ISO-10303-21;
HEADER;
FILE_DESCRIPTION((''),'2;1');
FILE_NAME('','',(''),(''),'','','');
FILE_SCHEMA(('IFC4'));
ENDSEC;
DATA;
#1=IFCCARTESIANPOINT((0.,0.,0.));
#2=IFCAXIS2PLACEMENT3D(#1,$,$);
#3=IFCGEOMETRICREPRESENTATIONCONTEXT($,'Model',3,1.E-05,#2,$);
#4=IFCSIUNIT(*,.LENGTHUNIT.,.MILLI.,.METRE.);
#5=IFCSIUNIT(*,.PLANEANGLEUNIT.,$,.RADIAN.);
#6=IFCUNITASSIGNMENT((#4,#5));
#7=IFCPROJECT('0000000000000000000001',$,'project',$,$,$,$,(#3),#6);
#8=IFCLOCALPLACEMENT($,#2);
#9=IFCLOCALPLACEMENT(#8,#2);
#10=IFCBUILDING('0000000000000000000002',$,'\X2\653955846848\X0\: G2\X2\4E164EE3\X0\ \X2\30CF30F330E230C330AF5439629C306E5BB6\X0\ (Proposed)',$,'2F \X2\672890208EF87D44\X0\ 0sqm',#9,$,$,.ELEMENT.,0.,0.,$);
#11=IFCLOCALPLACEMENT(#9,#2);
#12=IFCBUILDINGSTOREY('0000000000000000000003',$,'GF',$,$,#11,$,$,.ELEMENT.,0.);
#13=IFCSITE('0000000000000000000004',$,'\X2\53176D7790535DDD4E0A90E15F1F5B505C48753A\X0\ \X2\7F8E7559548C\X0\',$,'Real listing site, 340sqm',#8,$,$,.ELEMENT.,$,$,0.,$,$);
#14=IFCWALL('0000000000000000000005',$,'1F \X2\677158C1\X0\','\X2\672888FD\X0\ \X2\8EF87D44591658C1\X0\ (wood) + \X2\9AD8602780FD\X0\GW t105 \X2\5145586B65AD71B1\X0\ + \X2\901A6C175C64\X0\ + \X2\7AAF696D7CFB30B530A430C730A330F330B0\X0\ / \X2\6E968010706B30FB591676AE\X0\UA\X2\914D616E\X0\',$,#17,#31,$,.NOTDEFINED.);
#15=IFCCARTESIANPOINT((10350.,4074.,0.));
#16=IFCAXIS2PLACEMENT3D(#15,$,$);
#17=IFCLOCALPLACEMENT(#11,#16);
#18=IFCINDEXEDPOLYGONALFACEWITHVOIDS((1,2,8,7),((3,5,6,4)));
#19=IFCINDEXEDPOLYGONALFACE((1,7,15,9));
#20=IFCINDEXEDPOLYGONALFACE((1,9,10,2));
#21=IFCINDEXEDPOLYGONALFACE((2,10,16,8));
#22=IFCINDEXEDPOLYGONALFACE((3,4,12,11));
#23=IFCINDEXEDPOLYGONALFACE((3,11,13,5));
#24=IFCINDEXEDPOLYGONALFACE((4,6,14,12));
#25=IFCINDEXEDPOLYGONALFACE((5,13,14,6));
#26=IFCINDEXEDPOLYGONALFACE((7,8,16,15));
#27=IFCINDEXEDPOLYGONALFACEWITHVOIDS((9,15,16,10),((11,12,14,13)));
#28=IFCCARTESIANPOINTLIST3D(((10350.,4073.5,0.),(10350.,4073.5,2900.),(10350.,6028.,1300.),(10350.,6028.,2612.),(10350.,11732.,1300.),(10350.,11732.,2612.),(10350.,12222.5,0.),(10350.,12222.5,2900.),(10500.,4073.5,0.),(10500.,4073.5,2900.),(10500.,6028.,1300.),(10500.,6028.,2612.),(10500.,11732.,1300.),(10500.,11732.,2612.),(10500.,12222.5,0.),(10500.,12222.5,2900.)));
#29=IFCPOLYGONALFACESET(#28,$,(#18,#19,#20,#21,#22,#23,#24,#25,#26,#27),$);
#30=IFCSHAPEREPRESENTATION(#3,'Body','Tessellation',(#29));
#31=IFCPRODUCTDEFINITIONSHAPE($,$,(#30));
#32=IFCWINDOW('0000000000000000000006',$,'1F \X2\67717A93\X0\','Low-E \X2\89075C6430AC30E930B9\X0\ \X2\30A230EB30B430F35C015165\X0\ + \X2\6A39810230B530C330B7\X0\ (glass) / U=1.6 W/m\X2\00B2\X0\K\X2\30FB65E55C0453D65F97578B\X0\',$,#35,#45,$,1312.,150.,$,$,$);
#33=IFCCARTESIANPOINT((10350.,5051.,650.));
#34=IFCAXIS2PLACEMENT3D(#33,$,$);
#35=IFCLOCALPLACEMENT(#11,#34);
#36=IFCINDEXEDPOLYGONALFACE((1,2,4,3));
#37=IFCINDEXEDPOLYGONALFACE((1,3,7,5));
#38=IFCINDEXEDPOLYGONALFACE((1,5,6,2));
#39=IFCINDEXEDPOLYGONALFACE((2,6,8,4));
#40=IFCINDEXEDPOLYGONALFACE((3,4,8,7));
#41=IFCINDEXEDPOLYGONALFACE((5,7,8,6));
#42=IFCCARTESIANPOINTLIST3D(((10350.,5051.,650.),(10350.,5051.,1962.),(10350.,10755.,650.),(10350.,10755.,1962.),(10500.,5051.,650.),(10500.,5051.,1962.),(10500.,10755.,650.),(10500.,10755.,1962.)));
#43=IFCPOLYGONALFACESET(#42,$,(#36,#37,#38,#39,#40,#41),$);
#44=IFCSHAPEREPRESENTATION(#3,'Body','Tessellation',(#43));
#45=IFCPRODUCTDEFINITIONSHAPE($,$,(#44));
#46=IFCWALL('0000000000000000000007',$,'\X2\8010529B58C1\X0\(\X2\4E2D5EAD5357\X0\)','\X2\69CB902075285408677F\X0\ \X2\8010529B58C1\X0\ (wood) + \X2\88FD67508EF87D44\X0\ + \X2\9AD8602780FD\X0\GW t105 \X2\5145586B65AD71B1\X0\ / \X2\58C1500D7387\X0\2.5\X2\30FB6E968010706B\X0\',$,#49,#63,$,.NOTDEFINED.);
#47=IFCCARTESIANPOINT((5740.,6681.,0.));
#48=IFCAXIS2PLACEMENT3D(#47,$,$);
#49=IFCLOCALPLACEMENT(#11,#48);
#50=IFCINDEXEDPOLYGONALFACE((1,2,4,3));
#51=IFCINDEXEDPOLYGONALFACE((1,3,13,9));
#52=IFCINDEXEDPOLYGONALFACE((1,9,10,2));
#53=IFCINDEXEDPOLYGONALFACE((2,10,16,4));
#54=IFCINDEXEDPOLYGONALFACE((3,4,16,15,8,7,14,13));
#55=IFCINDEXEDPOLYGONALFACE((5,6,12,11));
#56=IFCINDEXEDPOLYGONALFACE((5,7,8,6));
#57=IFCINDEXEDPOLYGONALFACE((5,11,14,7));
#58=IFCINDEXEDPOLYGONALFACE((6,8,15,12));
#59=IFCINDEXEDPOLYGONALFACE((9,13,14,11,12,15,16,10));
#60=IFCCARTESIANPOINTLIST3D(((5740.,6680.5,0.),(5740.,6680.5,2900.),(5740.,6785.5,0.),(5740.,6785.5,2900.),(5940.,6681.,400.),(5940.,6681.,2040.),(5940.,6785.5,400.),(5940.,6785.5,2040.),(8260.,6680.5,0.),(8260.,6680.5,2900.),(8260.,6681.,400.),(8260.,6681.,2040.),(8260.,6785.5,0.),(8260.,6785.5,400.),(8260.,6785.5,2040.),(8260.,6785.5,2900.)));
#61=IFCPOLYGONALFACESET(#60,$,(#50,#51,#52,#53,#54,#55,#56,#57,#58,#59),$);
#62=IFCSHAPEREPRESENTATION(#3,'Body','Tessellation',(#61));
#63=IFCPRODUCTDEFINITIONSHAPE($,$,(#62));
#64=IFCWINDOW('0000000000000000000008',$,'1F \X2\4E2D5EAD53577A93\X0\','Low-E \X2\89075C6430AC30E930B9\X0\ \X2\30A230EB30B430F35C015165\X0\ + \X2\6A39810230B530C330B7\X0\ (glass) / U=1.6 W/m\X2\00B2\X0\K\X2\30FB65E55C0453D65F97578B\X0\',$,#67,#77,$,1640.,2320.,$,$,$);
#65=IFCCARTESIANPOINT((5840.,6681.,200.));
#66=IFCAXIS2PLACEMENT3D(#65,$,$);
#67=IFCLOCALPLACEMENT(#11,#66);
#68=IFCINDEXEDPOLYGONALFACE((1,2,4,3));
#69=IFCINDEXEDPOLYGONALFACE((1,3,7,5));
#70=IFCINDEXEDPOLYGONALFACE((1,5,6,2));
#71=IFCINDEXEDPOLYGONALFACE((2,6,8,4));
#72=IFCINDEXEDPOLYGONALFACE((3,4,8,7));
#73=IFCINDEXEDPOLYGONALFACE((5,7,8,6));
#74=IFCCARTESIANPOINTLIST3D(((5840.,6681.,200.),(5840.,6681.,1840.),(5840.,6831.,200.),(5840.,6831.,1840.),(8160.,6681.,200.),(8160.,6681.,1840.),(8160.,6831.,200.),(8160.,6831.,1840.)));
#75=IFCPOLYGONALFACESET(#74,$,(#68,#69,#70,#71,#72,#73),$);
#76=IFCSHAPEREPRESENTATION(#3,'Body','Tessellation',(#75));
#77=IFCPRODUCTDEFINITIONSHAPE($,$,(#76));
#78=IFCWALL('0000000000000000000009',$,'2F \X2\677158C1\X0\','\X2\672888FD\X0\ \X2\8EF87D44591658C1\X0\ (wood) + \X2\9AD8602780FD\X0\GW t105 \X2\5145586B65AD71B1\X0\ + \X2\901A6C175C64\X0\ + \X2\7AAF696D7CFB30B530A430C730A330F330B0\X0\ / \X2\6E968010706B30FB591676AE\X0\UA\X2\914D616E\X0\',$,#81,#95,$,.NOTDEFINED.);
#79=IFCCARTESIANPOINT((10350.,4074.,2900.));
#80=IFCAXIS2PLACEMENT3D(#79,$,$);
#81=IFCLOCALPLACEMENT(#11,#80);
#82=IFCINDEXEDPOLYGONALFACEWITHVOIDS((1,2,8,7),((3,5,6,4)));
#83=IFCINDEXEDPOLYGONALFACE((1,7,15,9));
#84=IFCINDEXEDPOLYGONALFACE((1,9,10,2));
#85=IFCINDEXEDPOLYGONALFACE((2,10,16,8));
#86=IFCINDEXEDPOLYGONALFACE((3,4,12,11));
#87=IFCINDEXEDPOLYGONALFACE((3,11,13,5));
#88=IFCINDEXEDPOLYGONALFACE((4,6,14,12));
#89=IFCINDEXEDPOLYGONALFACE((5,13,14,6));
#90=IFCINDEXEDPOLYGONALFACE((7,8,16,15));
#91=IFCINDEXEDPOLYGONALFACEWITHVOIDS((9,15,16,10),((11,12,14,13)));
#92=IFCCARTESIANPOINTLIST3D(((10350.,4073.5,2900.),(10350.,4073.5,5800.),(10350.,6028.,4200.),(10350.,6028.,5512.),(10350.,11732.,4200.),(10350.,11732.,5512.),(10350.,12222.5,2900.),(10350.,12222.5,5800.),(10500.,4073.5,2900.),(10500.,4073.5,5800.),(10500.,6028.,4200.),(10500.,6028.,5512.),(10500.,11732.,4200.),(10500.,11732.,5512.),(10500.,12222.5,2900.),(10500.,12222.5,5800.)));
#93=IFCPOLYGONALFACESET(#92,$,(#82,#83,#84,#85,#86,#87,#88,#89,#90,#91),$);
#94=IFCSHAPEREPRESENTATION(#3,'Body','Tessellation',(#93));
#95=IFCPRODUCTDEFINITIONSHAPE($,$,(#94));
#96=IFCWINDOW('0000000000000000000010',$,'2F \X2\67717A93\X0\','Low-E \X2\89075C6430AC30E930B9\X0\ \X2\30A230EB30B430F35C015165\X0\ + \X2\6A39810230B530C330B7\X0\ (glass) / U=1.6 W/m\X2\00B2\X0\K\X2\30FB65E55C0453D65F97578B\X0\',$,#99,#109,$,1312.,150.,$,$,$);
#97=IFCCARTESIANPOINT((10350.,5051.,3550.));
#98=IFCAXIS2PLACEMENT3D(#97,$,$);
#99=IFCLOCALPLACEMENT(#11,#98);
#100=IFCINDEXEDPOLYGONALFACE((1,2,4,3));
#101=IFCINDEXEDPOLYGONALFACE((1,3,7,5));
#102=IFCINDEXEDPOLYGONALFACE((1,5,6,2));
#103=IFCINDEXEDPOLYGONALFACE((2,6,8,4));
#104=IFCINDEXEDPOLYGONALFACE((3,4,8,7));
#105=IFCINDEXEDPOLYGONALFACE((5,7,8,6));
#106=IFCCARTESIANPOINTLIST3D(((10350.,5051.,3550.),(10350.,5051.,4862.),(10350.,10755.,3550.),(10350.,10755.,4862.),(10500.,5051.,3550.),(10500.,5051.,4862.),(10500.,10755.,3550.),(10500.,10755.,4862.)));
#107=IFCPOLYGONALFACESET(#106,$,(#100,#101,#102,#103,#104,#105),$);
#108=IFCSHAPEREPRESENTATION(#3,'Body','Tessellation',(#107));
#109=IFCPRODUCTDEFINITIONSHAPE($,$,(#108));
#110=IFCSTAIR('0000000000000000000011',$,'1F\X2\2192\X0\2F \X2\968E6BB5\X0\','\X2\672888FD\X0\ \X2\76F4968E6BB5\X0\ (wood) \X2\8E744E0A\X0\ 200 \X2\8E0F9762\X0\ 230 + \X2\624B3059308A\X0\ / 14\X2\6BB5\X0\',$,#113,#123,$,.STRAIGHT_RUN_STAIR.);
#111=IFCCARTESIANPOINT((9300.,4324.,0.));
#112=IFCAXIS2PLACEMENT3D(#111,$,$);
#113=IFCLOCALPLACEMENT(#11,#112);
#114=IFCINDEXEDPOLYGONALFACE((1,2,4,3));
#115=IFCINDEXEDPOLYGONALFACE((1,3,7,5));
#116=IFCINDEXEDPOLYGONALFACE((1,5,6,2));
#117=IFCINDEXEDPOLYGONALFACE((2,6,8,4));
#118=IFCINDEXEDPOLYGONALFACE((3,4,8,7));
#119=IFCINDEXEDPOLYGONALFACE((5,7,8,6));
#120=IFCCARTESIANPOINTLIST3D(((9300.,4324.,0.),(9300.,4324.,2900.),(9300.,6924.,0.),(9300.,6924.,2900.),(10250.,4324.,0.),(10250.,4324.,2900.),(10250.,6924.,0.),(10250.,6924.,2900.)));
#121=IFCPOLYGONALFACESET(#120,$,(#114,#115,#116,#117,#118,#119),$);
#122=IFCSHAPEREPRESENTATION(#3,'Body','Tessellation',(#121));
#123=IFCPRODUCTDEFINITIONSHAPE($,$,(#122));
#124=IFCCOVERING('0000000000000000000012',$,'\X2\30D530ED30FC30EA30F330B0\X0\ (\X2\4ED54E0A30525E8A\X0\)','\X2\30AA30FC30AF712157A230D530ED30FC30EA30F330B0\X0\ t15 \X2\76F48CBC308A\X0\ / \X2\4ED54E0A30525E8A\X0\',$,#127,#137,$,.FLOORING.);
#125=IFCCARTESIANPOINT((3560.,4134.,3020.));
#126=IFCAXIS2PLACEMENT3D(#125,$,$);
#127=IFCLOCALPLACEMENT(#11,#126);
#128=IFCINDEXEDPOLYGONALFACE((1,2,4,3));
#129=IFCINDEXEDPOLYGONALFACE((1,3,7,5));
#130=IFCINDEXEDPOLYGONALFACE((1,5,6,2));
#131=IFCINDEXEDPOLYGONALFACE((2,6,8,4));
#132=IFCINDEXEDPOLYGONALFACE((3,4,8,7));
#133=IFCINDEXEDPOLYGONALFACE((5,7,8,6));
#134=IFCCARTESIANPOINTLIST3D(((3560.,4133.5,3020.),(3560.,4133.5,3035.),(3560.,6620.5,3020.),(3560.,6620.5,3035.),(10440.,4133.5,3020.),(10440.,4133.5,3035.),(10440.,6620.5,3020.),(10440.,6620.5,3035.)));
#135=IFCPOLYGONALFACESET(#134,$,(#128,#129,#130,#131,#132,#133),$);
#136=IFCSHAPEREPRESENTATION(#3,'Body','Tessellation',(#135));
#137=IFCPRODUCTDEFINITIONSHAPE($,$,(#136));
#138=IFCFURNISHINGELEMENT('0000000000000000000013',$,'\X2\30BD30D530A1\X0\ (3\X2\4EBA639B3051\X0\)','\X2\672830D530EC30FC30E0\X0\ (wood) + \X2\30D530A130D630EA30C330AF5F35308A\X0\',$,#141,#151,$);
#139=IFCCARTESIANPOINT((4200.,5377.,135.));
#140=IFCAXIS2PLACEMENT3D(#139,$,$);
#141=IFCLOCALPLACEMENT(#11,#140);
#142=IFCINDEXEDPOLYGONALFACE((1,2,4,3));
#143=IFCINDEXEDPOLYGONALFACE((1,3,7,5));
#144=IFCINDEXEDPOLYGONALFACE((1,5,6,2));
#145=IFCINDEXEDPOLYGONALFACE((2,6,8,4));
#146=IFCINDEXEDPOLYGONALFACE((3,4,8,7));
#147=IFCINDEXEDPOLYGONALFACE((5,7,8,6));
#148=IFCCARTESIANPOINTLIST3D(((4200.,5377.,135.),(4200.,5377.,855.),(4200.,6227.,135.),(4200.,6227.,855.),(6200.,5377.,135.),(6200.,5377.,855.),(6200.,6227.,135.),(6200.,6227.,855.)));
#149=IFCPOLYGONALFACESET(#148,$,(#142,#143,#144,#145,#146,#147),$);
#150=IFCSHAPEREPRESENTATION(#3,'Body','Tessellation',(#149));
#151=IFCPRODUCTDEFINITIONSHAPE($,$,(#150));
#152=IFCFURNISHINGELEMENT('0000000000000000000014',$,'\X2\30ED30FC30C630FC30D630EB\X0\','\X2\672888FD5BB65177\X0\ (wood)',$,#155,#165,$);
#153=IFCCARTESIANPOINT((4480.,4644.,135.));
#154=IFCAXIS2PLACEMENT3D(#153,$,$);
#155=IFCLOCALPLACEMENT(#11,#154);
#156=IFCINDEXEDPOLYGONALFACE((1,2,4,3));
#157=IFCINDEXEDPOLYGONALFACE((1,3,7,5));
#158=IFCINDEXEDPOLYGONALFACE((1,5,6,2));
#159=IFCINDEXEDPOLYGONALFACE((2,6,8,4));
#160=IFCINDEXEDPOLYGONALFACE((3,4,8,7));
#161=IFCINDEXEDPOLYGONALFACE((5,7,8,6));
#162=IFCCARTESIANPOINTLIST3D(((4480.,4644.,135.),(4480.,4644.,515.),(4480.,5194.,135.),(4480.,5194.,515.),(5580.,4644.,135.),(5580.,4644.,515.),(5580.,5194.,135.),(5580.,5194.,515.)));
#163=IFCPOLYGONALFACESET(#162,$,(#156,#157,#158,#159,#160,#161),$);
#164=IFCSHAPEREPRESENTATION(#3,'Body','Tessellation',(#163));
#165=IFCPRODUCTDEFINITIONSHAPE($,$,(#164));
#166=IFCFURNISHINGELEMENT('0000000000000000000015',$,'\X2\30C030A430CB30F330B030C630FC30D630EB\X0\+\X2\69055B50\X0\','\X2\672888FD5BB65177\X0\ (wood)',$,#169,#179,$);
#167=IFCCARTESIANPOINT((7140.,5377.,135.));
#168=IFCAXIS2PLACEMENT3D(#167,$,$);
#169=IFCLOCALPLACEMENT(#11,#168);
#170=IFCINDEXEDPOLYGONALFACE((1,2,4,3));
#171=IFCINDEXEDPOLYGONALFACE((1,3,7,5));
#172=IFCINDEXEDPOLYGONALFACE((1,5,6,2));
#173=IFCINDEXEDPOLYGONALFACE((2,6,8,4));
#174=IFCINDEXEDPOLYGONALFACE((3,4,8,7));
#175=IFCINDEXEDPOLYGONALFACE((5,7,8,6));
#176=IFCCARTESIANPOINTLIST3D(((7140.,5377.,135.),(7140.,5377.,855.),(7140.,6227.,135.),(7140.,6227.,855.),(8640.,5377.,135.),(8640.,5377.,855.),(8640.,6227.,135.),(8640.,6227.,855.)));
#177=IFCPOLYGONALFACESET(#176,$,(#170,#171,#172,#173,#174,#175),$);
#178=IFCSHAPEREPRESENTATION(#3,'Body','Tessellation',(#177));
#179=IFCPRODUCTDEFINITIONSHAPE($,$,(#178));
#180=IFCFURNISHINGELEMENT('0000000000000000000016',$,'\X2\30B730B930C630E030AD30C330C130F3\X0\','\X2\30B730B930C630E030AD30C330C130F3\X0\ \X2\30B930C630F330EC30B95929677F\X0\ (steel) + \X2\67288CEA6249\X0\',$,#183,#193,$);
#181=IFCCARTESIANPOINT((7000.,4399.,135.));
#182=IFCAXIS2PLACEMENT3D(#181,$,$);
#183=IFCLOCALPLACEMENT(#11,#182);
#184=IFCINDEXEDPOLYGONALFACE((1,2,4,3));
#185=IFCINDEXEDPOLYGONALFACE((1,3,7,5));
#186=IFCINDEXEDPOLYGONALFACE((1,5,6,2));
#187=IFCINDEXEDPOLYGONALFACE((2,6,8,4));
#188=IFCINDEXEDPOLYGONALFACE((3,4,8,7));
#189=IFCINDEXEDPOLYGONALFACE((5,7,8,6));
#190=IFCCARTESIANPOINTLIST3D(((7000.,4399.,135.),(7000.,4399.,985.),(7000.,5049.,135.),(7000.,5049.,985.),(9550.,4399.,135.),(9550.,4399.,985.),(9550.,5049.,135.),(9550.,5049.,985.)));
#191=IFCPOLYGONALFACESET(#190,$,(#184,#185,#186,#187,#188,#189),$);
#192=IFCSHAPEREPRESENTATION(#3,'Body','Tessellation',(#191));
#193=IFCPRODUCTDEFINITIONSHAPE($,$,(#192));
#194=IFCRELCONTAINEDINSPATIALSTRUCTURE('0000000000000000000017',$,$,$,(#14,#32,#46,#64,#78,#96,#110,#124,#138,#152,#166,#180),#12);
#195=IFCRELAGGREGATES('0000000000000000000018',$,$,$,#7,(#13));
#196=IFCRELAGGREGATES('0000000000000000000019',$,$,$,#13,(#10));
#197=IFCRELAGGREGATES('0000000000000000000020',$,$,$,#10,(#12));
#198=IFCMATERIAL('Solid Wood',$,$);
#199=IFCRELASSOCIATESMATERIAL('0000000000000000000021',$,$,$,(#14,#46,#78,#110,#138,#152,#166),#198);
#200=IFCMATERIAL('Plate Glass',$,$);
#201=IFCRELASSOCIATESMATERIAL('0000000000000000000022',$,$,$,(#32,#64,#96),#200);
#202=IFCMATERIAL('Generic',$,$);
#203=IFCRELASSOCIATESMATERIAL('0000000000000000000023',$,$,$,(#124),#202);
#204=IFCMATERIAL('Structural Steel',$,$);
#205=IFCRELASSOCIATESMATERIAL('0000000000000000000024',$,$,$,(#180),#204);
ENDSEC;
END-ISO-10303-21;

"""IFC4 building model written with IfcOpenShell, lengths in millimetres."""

from ifc_helpers import new_model, si_unit, frame, frame_2d, origin, place, context, project, spatial, rectangle, extrude, material, element, fill, save


model = new_model("IFC4")

# Units and contexts
model_context = context("Model", 3, precision=1e-05, world=origin())
ifc_project = project(units=[si_unit("LENGTHUNIT", "METRE", prefix="MILLI"), si_unit("PLANEANGLEUNIT", "RADIAN")], contexts=[model_context])

# Site, building, storey
site_placement = place(None, origin())
site = spatial("IfcSite", under=ifc_project, at=site_placement, Name="北海道川上郡弟子屈町 美留和", ObjectType="Real listing site, 340sqm", CompositionType="ELEMENT", RefElevation=0.0)
building_placement = place(site_placement, origin())
building = spatial("IfcBuilding", under=site, at=building_placement, Name="改善案: G2世代 ハンモック吹抜の家 (Proposed)", ObjectType="2F 木造軸組 0sqm", CompositionType="ELEMENT", ElevationOfRefHeight=0.0, ElevationOfTerrain=0.0)
storey_placement = place(building_placement, origin())
storey = spatial("IfcBuildingStorey", under=building, at=storey_placement, Name="GF", CompositionType="ELEMENT", Elevation=0.0)

# Shared definitions
ifc_material_1 = material(Name="Solid Wood")

# Walls, openings, windows
wall_1_placement = place(storey_placement, frame((10350.0, 4074.0, 0.0)))
wall_1 = element("IfcWall", 1, at=wall_1_placement, inside=storey, material=ifc_material_1, Name="1F 東壁", Description="木製 軸組外壁 (wood) + 高性能GW t105 充填断熱 + 通気層 + 窯業系サイディング / 準耐火・外皮UA配慮", PredefinedType="NOTDEFINED", context=model_context, shape_type="SweptSolid", body=[
    extrude(rectangle(XDim=150.0, YDim=8149.0, at=frame_2d((75.0, 4074.0))), frame((10350.0, 4074.0, 0.0)), (0.0, 0.0, 1.0), 2900.0),
])
opening_1_placement = place(storey_placement, frame((10350.0, 5051.0, 650.0)))
opening_1 = element("IfcOpeningElement", 2, at=opening_1_placement, cuts=wall_1, PredefinedType="NOTDEFINED", context=model_context, shape_type="SweptSolid", body=[
    extrude(rectangle(XDim=150.0, YDim=5704.0, at=frame_2d((75.0, 2852.0))), frame((10350.0, 5051.0, 650.0)), (0.0, 0.0, 1.0), 1312.0),
])
ifc_material_2 = material(Name="Plate Glass")
window_1_placement = place(storey_placement, frame((10350.0, 5051.0, 650.0)))
window_1 = element("IfcWindow", 3, at=window_1_placement, inside=storey, material=ifc_material_2, Name="1F 東窓", Description="Low-E 複層ガラス アルゴン封入 + 樹脂サッシ (glass) / U=1.6 W/m²K・日射取得型", OverallHeight=1312.0, OverallWidth=150.0, context=model_context, shape_type="SweptSolid", body=[
    extrude(rectangle(XDim=150.0, YDim=5704.0, at=frame_2d((75.0, 2852.0))), frame((10350.0, 5051.0, 650.0)), (0.0, 0.0, 1.0), 1312.0),
])
fill(opening_1, window_1)
wall_2_placement = place(storey_placement, frame((5740.0, 6681.0, 0.0)))
wall_2 = element("IfcWall", 4, at=wall_2_placement, inside=storey, material=ifc_material_1, Name="耐力壁(中庭南)", Description="構造用合板 耐力壁 (wood) + 製材軸組 + 高性能GW t105 充填断熱 / 壁倍率2.5・準耐火", PredefinedType="NOTDEFINED", context=model_context, shape_type="SweptSolid", body=[
    extrude(rectangle(XDim=2520.0, YDim=105.0, at=frame_2d((1260.0, 52.0))), frame((5740.0, 6681.0, 0.0)), (0.0, 0.0, 1.0), 2900.0),
])
opening_2_placement = place(storey_placement, frame((5840.0, 6681.0, 200.0)))
opening_2 = element("IfcOpeningElement", 5, at=opening_2_placement, cuts=wall_2, PredefinedType="NOTDEFINED", context=model_context, shape_type="SweptSolid", body=[
    extrude(rectangle(XDim=2320.0, YDim=150.0, at=frame_2d((1160.0, 75.0))), frame((5840.0, 6681.0, 200.0)), (0.0, 0.0, 1.0), 1640.0),
])
window_2_placement = place(storey_placement, frame((5840.0, 6681.0, 200.0)))
window_2 = element("IfcWindow", 6, at=window_2_placement, inside=storey, material=ifc_material_2, Name="1F 中庭南窓", Description="Low-E 複層ガラス アルゴン封入 + 樹脂サッシ (glass) / U=1.6 W/m²K・日射取得型", OverallHeight=1640.0, OverallWidth=2320.0, context=model_context, shape_type="SweptSolid", body=[
    extrude(rectangle(XDim=2320.0, YDim=150.0, at=frame_2d((1160.0, 75.0))), frame((5840.0, 6681.0, 200.0)), (0.0, 0.0, 1.0), 1640.0),
])
fill(opening_2, window_2)

# Wall, opening, window
wall_3_placement = place(storey_placement, frame((10350.0, 4074.0, 2900.0)))
wall_3 = element("IfcWall", 7, at=wall_3_placement, inside=storey, material=ifc_material_1, Name="2F 東壁", Description="木製 軸組外壁 (wood) + 高性能GW t105 充填断熱 + 通気層 + 窯業系サイディング / 準耐火・外皮UA配慮", PredefinedType="NOTDEFINED", context=model_context, shape_type="SweptSolid", body=[
    extrude(rectangle(XDim=150.0, YDim=8149.0, at=frame_2d((75.0, 4074.0))), frame((10350.0, 4074.0, 2900.0)), (0.0, 0.0, 1.0), 2900.0),
])
opening_3_placement = place(storey_placement, frame((10350.0, 5051.0, 3550.0)))
opening_3 = element("IfcOpeningElement", 8, at=opening_3_placement, cuts=wall_3, PredefinedType="NOTDEFINED", context=model_context, shape_type="SweptSolid", body=[
    extrude(rectangle(XDim=150.0, YDim=5704.0, at=frame_2d((75.0, 2852.0))), frame((10350.0, 5051.0, 3550.0)), (0.0, 0.0, 1.0), 1312.0),
])
window_3_placement = place(storey_placement, frame((10350.0, 5051.0, 3550.0)))
window_3 = element("IfcWindow", 9, at=window_3_placement, inside=storey, material=ifc_material_2, Name="2F 東窓", Description="Low-E 複層ガラス アルゴン封入 + 樹脂サッシ (glass) / U=1.6 W/m²K・日射取得型", OverallHeight=1312.0, OverallWidth=150.0, context=model_context, shape_type="SweptSolid", body=[
    extrude(rectangle(XDim=150.0, YDim=5704.0, at=frame_2d((75.0, 2852.0))), frame((10350.0, 5051.0, 3550.0)), (0.0, 0.0, 1.0), 1312.0),
])
fill(opening_3, window_3)

# Stair
stair_placement = place(storey_placement, frame((9300.0, 4324.0, 0.0)))
element("IfcStair", 10, at=stair_placement, inside=storey, material=ifc_material_1, Name="1F→2F 階段", Description="木製 直階段 (wood) 蹴上 200 踏面 230 + 手すり / 14段", PredefinedType="STRAIGHT_RUN_STAIR", context=model_context, shape_type="SweptSolid", body=[
    extrude(rectangle(XDim=950.0, YDim=2600.0, at=frame_2d((475.0, 1300.0))), frame((9300.0, 4324.0, 0.0)), (0.0, 0.0, 1.0), 2900.0),
])

# Covering
ifc_material_3 = material(Name="Generic")
covering_placement = place(storey_placement, frame((3560.0, 4134.0, 3020.0)))
element("IfcCovering", 11, at=covering_placement, inside=storey, material=ifc_material_3, Name="フローリング (仕上げ床)", Description="オーク無垢フローリング t15 直貼り / 仕上げ床", PredefinedType="FLOORING", context=model_context, shape_type="SweptSolid", body=[
    extrude(rectangle(XDim=6880.0, YDim=2487.0, at=frame_2d((3440.0, 1243.0))), frame((3560.0, 4134.0, 3020.0)), (0.0, 0.0, 1.0), 15.0),
])

# Furnishing elements
furnishing_1_placement = place(storey_placement, frame((4200.0, 5377.0, 135.0)))
element("IfcFurnishingElement", 12, at=furnishing_1_placement, inside=storey, material=ifc_material_1, Name="ソファ (3人掛け)", Description="木フレーム (wood) + ファブリック張り", context=model_context, shape_type="SweptSolid", body=[
    extrude(rectangle(XDim=2000.0, YDim=850.0, at=frame_2d((1000.0, 425.0))), frame((4200.0, 5377.0, 135.0)), (0.0, 0.0, 1.0), 720.0),
])
furnishing_2_placement = place(storey_placement, frame((4480.0, 4644.0, 135.0)))
element("IfcFurnishingElement", 13, at=furnishing_2_placement, inside=storey, material=ifc_material_1, Name="ローテーブル", Description="木製家具 (wood)", context=model_context, shape_type="SweptSolid", body=[
    extrude(rectangle(XDim=1100.0, YDim=550.0, at=frame_2d((550.0, 275.0))), frame((4480.0, 4644.0, 135.0)), (0.0, 0.0, 1.0), 380.0),
])
furnishing_3_placement = place(storey_placement, frame((7140.0, 5377.0, 135.0)))
element("IfcFurnishingElement", 14, at=furnishing_3_placement, inside=storey, material=ifc_material_1, Name="ダイニングテーブル+椅子", Description="木製家具 (wood)", context=model_context, shape_type="SweptSolid", body=[
    extrude(rectangle(XDim=1500.0, YDim=850.0, at=frame_2d((750.0, 425.0))), frame((7140.0, 5377.0, 135.0)), (0.0, 0.0, 1.0), 720.0),
])
ifc_material_4 = material(Name="Structural Steel")
furnishing_4_placement = place(storey_placement, frame((7000.0, 4399.0, 135.0)))
element("IfcFurnishingElement", 15, at=furnishing_4_placement, inside=storey, material=ifc_material_4, Name="システムキッチン", Description="システムキッチン ステンレス天板 (steel) + 木質扉", context=model_context, shape_type="SweptSolid", body=[
    extrude(rectangle(XDim=2550.0, YDim=650.0, at=frame_2d((1275.0, 325.0))), frame((7000.0, 4399.0, 135.0)), (0.0, 0.0, 1.0), 850.0),
])

save(model, "model.ifc")
